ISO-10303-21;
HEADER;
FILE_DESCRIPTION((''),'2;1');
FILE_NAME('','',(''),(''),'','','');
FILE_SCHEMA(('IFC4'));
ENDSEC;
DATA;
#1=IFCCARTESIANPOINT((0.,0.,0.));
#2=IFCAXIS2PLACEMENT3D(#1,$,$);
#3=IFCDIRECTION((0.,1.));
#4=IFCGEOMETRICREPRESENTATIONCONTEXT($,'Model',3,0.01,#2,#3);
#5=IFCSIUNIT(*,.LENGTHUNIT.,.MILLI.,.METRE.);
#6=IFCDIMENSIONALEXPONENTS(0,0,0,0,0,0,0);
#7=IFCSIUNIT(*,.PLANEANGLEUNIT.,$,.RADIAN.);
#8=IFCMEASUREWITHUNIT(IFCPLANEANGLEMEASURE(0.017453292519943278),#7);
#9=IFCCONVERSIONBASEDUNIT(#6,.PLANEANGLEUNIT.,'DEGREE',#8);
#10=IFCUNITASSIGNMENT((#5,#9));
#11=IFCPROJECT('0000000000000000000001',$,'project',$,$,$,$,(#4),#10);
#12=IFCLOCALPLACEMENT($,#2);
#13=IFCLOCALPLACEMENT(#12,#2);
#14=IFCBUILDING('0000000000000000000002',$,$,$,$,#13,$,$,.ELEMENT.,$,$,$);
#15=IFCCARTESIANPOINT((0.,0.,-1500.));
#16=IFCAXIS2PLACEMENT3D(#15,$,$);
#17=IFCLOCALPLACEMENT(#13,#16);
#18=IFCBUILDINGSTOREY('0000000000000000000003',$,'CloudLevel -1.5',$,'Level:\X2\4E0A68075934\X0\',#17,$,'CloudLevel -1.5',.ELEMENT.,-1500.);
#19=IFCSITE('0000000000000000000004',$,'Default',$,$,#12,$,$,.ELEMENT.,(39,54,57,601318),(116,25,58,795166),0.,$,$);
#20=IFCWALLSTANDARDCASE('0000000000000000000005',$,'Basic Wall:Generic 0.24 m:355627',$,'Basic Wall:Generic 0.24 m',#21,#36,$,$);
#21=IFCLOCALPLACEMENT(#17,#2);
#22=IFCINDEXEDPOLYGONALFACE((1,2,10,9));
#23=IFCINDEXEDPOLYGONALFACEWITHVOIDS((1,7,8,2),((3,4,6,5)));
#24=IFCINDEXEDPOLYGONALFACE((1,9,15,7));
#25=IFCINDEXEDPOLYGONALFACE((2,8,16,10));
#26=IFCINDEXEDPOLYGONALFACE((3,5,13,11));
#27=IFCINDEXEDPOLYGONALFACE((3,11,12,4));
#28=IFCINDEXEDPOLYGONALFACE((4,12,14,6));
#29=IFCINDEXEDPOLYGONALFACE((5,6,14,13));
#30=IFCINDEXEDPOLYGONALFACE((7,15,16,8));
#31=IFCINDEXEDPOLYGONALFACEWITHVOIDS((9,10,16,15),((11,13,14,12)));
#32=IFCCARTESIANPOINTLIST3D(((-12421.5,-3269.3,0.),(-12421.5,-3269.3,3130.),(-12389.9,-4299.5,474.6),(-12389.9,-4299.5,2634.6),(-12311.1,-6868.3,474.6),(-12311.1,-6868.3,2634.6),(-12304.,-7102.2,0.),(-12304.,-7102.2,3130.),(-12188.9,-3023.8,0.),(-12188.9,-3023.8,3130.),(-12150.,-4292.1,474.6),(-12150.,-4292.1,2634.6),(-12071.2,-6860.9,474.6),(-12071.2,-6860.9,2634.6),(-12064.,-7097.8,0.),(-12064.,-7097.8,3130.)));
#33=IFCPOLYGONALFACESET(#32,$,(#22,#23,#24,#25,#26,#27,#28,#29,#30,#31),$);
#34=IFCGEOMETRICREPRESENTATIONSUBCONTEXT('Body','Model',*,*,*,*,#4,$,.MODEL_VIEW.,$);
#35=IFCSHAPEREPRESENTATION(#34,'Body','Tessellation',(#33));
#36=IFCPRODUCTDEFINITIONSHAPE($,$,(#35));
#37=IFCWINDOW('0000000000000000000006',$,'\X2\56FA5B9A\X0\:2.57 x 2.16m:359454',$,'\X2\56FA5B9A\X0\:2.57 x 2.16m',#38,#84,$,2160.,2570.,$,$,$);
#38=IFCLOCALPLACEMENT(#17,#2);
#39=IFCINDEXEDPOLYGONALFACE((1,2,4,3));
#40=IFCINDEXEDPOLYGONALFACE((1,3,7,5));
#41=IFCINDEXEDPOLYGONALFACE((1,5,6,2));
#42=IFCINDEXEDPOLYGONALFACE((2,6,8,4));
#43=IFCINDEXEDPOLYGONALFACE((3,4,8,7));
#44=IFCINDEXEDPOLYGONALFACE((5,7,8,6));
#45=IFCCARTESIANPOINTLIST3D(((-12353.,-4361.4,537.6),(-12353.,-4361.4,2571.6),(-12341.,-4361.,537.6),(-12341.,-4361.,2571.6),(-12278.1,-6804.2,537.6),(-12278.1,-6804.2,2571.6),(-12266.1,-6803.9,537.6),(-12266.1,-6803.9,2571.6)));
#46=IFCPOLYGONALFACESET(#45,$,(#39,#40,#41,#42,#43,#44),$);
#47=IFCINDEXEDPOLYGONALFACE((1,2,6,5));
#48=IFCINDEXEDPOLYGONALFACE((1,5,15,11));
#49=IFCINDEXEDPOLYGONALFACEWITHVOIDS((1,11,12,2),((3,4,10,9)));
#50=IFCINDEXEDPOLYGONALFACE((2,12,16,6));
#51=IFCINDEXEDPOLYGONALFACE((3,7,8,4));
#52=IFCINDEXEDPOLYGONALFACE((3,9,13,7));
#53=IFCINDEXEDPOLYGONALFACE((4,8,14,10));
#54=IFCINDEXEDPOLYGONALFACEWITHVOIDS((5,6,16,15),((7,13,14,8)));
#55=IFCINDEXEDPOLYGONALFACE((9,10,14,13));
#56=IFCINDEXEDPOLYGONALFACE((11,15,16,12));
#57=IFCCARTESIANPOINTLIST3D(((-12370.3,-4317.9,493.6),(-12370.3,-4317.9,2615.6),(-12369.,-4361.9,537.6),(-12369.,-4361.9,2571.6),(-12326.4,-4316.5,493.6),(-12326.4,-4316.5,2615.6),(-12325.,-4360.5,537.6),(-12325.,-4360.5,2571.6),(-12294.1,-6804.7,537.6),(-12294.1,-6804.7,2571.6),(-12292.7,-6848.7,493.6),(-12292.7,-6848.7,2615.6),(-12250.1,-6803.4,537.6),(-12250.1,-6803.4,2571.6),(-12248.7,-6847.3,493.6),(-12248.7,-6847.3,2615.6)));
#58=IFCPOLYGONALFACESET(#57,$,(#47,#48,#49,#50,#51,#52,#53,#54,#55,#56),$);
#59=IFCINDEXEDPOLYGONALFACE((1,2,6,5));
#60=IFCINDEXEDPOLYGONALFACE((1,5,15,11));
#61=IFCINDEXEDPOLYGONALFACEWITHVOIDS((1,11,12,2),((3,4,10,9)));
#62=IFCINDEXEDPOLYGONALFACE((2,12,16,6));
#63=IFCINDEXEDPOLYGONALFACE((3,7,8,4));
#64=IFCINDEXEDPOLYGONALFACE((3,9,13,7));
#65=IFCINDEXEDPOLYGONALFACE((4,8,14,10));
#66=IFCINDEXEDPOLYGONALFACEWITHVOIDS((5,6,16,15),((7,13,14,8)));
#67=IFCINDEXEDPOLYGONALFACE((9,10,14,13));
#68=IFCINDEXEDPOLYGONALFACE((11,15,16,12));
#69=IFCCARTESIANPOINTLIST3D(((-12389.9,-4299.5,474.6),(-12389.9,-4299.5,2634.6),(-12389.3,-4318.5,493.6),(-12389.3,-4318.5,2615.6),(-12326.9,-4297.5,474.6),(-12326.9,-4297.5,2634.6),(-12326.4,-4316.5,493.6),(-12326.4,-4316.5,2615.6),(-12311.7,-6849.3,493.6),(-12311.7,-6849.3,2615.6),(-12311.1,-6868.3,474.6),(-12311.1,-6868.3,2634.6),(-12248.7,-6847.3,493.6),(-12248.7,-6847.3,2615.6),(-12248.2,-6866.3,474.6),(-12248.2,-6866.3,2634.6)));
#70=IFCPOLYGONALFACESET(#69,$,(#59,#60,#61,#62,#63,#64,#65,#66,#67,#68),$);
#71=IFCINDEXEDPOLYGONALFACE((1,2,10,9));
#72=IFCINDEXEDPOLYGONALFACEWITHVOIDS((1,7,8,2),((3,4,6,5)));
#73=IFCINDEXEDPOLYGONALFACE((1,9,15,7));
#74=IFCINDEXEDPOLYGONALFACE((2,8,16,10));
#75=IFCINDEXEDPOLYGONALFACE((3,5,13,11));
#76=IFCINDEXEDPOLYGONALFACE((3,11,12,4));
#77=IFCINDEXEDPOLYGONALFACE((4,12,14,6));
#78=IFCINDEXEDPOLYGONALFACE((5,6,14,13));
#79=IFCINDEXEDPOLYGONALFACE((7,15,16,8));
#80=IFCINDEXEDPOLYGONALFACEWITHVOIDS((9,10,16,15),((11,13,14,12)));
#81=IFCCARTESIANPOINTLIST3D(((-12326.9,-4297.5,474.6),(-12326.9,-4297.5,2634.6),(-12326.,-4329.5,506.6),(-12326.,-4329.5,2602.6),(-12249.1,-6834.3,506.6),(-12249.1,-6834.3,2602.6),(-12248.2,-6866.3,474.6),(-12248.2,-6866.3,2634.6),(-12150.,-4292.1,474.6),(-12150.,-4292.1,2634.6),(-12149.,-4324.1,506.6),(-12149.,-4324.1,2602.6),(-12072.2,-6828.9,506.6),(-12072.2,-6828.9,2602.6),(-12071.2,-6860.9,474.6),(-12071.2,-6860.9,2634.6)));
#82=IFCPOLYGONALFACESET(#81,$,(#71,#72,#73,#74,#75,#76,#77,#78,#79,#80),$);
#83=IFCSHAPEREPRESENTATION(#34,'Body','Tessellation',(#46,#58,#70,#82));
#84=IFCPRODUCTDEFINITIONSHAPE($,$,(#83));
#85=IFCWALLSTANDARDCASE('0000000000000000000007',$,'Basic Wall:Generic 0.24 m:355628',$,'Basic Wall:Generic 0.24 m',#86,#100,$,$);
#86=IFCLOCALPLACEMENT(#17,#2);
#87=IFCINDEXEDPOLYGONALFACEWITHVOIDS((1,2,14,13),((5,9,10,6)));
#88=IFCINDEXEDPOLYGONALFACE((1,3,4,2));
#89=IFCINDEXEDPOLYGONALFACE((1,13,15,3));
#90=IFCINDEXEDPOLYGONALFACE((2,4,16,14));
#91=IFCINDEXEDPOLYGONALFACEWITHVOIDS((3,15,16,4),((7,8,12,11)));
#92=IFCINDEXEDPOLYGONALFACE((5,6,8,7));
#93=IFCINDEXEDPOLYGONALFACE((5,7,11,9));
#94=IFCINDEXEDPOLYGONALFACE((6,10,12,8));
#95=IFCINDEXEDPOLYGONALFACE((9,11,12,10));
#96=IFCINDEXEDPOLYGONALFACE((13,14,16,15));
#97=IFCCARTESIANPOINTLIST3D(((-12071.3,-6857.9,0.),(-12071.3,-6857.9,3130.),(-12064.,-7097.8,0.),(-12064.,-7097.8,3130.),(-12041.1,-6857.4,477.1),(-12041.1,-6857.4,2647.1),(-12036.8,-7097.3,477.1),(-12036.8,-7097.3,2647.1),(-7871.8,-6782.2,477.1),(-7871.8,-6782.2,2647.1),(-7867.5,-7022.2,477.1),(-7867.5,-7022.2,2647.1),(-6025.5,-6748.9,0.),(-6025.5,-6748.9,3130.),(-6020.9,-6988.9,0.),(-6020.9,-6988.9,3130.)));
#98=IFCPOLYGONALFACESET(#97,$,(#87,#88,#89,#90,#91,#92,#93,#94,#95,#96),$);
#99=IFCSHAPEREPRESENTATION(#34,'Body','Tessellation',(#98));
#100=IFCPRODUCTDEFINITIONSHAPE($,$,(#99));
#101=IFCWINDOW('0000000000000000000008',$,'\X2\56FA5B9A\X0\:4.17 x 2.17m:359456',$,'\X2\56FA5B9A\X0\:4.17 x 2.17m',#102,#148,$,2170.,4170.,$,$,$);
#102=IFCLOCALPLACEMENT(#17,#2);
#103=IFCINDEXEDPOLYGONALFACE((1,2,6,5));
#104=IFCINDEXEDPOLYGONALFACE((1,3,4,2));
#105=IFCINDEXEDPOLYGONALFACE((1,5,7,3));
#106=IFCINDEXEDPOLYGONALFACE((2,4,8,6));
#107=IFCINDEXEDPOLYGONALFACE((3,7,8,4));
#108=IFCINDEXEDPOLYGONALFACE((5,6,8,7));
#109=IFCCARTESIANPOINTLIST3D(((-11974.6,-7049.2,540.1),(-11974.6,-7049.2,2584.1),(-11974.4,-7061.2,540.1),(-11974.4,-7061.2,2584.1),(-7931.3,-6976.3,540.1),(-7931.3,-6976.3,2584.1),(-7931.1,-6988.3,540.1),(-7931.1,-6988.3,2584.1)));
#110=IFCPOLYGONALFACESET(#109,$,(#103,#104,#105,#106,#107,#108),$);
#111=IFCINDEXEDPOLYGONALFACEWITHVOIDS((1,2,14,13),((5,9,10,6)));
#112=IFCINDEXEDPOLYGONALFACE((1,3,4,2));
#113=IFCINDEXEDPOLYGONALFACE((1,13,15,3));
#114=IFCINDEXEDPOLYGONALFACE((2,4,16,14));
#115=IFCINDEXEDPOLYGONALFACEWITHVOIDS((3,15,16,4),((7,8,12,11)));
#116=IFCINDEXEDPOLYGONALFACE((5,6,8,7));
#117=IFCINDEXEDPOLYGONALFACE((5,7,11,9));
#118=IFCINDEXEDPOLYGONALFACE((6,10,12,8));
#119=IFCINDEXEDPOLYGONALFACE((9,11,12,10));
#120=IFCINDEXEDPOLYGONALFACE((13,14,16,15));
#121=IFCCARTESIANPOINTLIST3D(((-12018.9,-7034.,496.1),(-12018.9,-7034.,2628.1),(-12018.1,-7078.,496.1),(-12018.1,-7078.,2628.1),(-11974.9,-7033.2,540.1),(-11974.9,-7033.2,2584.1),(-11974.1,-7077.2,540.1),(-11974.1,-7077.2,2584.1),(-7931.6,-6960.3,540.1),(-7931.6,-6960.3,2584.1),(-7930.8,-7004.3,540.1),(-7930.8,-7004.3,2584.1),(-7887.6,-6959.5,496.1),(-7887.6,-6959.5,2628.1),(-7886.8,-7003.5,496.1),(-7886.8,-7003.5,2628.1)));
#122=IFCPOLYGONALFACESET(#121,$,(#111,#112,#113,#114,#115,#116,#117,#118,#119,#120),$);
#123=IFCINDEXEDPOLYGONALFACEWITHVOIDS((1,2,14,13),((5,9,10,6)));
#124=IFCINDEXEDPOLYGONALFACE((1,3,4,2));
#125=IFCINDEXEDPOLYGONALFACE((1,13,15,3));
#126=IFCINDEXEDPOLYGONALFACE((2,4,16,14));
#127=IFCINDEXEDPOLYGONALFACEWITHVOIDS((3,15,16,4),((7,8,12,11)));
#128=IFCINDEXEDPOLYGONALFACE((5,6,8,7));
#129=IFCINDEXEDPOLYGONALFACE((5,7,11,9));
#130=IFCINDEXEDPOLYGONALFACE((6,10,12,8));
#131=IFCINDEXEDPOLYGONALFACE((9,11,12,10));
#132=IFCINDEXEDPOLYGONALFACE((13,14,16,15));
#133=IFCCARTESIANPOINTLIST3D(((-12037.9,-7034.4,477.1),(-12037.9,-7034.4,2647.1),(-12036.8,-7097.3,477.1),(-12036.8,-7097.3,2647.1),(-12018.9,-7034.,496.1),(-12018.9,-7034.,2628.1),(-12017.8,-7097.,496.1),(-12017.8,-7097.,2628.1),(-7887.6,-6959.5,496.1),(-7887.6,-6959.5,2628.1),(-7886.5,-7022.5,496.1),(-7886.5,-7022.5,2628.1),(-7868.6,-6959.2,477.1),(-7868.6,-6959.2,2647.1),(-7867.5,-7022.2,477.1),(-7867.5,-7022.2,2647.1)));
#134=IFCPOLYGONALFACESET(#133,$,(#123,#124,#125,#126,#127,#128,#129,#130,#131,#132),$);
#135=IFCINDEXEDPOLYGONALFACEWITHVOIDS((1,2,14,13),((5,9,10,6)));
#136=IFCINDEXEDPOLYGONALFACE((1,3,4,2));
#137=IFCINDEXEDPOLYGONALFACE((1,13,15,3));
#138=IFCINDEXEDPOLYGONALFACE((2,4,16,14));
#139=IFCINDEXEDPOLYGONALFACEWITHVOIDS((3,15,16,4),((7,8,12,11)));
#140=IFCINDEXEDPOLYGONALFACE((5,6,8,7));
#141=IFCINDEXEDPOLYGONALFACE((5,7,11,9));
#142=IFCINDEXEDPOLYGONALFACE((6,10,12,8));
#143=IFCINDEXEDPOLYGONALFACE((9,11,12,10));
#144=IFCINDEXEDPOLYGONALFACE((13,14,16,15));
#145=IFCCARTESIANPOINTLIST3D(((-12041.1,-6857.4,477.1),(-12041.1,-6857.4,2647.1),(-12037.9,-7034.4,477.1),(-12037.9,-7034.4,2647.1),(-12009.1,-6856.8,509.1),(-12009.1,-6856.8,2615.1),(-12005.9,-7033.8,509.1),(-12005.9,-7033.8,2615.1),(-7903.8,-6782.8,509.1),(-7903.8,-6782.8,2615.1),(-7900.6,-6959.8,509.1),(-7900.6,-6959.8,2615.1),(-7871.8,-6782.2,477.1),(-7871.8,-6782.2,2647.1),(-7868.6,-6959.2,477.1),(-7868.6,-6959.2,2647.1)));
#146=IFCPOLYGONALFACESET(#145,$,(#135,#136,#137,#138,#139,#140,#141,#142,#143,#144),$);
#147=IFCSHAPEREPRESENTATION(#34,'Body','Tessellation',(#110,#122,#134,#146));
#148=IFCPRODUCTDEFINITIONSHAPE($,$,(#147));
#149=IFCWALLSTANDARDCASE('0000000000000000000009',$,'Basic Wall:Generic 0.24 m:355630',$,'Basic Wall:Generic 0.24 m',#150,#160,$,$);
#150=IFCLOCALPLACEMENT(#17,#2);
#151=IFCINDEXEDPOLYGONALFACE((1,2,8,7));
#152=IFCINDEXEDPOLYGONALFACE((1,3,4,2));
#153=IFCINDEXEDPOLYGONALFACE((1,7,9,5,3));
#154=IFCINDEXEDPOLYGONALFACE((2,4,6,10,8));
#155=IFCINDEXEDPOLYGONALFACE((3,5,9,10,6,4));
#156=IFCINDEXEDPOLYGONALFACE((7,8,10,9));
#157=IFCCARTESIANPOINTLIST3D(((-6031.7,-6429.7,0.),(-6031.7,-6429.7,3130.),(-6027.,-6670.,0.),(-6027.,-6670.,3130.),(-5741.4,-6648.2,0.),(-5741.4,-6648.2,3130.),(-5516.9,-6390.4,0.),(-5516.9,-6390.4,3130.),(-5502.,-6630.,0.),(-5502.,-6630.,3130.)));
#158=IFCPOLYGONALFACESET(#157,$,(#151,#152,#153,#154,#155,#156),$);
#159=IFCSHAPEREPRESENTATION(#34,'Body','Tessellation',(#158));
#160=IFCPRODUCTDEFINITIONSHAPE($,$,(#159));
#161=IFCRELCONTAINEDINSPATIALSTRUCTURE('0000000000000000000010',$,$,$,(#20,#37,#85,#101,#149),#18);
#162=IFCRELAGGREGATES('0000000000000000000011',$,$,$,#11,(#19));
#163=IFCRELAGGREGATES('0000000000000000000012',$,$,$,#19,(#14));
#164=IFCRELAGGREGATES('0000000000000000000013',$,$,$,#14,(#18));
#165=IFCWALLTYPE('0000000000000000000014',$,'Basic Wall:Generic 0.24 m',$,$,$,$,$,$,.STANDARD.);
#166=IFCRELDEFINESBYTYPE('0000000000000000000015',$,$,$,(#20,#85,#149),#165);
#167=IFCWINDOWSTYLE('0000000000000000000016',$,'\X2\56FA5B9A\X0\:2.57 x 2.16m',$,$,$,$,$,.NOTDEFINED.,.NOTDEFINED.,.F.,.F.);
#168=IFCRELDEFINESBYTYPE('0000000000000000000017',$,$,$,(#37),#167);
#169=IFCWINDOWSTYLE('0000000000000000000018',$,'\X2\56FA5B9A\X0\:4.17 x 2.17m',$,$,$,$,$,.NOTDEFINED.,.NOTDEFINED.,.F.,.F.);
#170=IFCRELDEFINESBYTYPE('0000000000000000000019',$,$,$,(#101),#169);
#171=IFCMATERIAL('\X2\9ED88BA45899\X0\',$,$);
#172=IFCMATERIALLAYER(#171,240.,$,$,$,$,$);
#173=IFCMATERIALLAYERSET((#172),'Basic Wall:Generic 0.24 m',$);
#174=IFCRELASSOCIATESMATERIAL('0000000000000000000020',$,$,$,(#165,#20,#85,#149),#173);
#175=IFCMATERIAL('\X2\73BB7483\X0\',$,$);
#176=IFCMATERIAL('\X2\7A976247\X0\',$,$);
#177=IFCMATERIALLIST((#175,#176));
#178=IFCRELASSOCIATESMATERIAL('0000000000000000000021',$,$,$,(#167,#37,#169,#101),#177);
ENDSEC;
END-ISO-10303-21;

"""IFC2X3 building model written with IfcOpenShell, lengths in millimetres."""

from ifc_helpers import new_model, entity, si_unit, converted_unit, direction, frame, frame_2d, origin, place, context, subcontext, project, spatial, polyline, rectangle, outline, extrude, source, transform, mapped, material, material_list, layer, layer_set, layer_usage, type_object, type_shapes, element, fill, save


model = new_model("IFC2X3")

# Units and contexts
model_context = context("Model", 3, precision=0.01, world=origin(), true_north=direction((0.0, 1.0)))
body_context = subcontext(model_context, "Body", "Model", "MODEL_VIEW")
ifc_project = project(units=[si_unit("LENGTHUNIT", "METRE", prefix="MILLI"), converted_unit("PLANEANGLEUNIT", "DEGREE", entity("IfcPlaneAngleMeasure", 0.017453292519943278), si_unit("PLANEANGLEUNIT", "RADIAN"), dimensions=[0, 0, 0, 0, 0, 0, 0])], contexts=[model_context])

# Site, building, storey
site_placement = place(None, origin())
site = spatial("IfcSite", under=ifc_project, at=site_placement, Name="Default", CompositionType="ELEMENT", RefLatitude=(39, 54, 57, 601318), RefLongitude=(116, 25, 58, 795166), RefElevation=0.0)
building_placement = place(site_placement, origin())
building = spatial("IfcBuilding", under=site, at=building_placement, CompositionType="ELEMENT")
storey_placement = place(building_placement, frame((0.0, 0.0, -1500.0)))
storey = spatial("IfcBuildingStorey", under=building, at=storey_placement, Name="CloudLevel -1.5", ObjectType="Level:上标头", LongName="CloudLevel -1.5", CompositionType="ELEMENT", Elevation=-1500.0)

# Shared definitions
ifc_material_1 = material(Name="默认墙")
ifc_layer_1 = layer(ifc_material_1, 240.0)
ifc_layer_set_1 = layer_set([ifc_layer_1], Name="Basic Wall:Generic 0.24 m")
ifc_layer_usage_1 = layer_usage(ifc_layer_set_1, "AXIS2", "NEGATIVE", 120.0)
wall_type_1 = type_object("IfcWallType", Name="Basic Wall:Generic 0.24 m", PredefinedType="STANDARD", material=ifc_layer_set_1)

# Wall, opening, window
wall_1_placement = place(storey_placement, frame((-12308.9, -3027.5, 0.0), z_axis=(0.0, 0.0, 1.0), x_axis=(0.030657, -0.99953, 0.0)))
wall_1 = element("IfcWallStandardCase", 1, at=wall_1_placement, inside=storey, type_object=wall_type_1, material=ifc_layer_usage_1, Name="Basic Wall:Generic 0.24 m:355627", ObjectType="Basic Wall:Generic 0.24 m", context=body_context, shape_type="SweptSolid", body=[
    extrude(outline(polyline([(4072.9, -120.0), (4075.9, 120.0), (3835.9, 120.0), (0.0, 120.0), (238.3, -120.0), (348.5, -120.0), (4072.9, -120.0)])), origin(), (0.0, 0.0, 1.0), 3130.0),
])
opening_1_placement = place(wall_1_placement, frame((3838.9, 120.0, 474.6)))
opening_1 = element("IfcOpeningElement", 2, at=opening_1_placement, cuts=wall_1, ObjectType="Opening", context=body_context, shape_type="SweptSolid", body=[
    extrude(rectangle(XDim=2160.0, YDim=2570.0, at=frame_2d((1080.0, 1285.0), x_axis=(1.0, 0.0))), frame((0.0, 0.0, 0.0), z_axis=(0.0, -1.0, 0.0), x_axis=(0.0, 0.0, 1.0)), (0.0, 0.0, 1.0), 240.0),
])
ifc_material_2 = material(Name="玻璃")
ifc_material_3 = material(Name="窗扇")
ifc_material_list_1 = material_list([ifc_material_2, ifc_material_3])
window_style_1 = type_object("IfcWindowStyle", Name="固定:2.57 x 2.16m", ConstructionType="NOTDEFINED", OperationType="NOTDEFINED", ParameterTakesPrecedence=False, Sizeable=False, material=ifc_material_list_1)
shared_shape_1 = source(origin(), body_context, "Body", "SweptSolid", [
    extrude(rectangle(XDim=2444.0, YDim=12.0, at=frame_2d((0.0, 0.0), x_axis=(1.0, 0.0))), frame((1285.0, 225.0, 63.0), z_axis=(0.0, 0.0, 1.0), x_axis=(-1.0, 0.0, 0.0)), (0.0, 0.0, 1.0), 2034.0),
    extrude(outline(polyline([(-1266.0, -1061.0), (1266.0, -1061.0), (1266.0, 1061.0), (-1266.0, 1061.0), (-1266.0, -1061.0)]), holes=[polyline([(-1222.0, -1017.0), (-1222.0, 1017.0), (1222.0, 1017.0), (1222.0, -1017.0), (-1222.0, -1017.0)])]), frame((1285.0, 247.0, 1080.0), z_axis=(0.0, -1.0, 0.0), x_axis=(-1.0, 0.0, 0.0)), (0.0, 0.0, 1.0), 44.0),
    extrude(outline(polyline([(-1285.0, -1080.0), (1285.0, -1080.0), (1285.0, 1080.0), (-1285.0, 1080.0), (-1285.0, -1080.0)]), holes=[polyline([(-1266.0, -1061.0), (-1266.0, 1061.0), (1266.0, 1061.0), (1266.0, -1061.0), (-1266.0, -1061.0)])]), frame((1285.0, 266.0, 1080.0), z_axis=(0.0, -1.0, 0.0), x_axis=(-1.0, 0.0, 0.0)), (0.0, 0.0, 1.0), 63.0),
    extrude(outline(polyline([(-1285.0, -1080.0), (1285.0, -1080.0), (1285.0, 1080.0), (-1285.0, 1080.0), (-1285.0, -1080.0)]), holes=[polyline([(-1253.0, -1048.0), (-1253.0, 1048.0), (1253.0, 1048.0), (1253.0, -1048.0), (-1253.0, -1048.0)])]), frame((1285.0, 203.0, 1080.0), z_axis=(0.0, -1.0, 0.0), x_axis=(-1.0, 0.0, 0.0)), (0.0, 0.0, 1.0), 177.0),
])
type_shapes(window_style_1, [shared_shape_1])
window_1_placement = place(opening_1_placement, frame((0.0, 26.0, 0.0), z_axis=(0.0, 0.0, 1.0), x_axis=(-1.0, 0.0, 0.0)))
window_1 = element("IfcWindow", 3, at=window_1_placement, inside=storey, type_object=window_style_1, material=ifc_material_list_1, Name="固定:2.57 x 2.16m:359454", ObjectType="固定:2.57 x 2.16m", OverallHeight=2160.0, OverallWidth=2570.0, context=body_context, shape_type="MappedRepresentation", body=[
    mapped(shared_shape_1, transform((0.0, 0.0, 0.0), scale=1.0)),
])
fill(opening_1, window_1)

# Wall, openings, window
wall_2_placement = place(storey_placement, frame((-12069.2, -6977.9, 0.0), z_axis=(0.0, 0.0, 1.0), x_axis=(0.999838, 0.018026, 0.0)))
wall_2 = element("IfcWallStandardCase", 4, at=wall_2_placement, inside=storey, type_object=wall_type_1, material=ifc_layer_usage_1, Name="Basic Wall:Generic 0.24 m:355628", ObjectType="Basic Wall:Generic 0.24 m", context=body_context, shape_type="SweptSolid", body=[
    extrude(outline(polyline([(6047.1, -120.0), (6046.8, 120.0), (5716.8, 120.0), (0.0, 120.0), (3.0, -120.0), (6047.1, -120.0)])), origin(), (0.0, 0.0, 1.0), 3130.0),
])
opening_2_placement = place(wall_2_placement, origin())
element("IfcOpeningElement", 5, at=opening_2_placement, cuts=wall_2, ObjectType="Opening", context=body_context, shape_type="SweptSolid", body=[
    extrude(rectangle(XDim=2160.0, YDim=240.0, at=frame_2d((0.0, 0.0), x_axis=(0.0, 1.0))), frame((-120.0, 115.5, 1554.6), z_axis=(-0.012634, 0.99992, 0.0), x_axis=(-0.99992, -0.012634, 0.0)), (0.0, 0.0, 1.0), 2570.0),
])
opening_3_placement = place(wall_2_placement, frame((4200.2, 120.0, 477.1)))
opening_3 = element("IfcOpeningElement", 6, at=opening_3_placement, cuts=wall_2, ObjectType="Opening", context=body_context, shape_type="SweptSolid", body=[
    extrude(rectangle(XDim=2170.0, YDim=4170.0, at=frame_2d((1085.0, 2085.0), x_axis=(1.0, 0.0))), frame((0.0, 0.0, 0.0), z_axis=(0.0, -1.0, 0.0), x_axis=(0.0, 0.0, 1.0)), (0.0, 0.0, 1.0), 240.0),
])
window_style_2 = type_object("IfcWindowStyle", Name="固定:4.17 x 2.17m", ConstructionType="NOTDEFINED", OperationType="NOTDEFINED", ParameterTakesPrecedence=False, Sizeable=False, material=ifc_material_list_1)
shared_shape_2 = source(origin(), body_context, "Body", "SweptSolid", [
    extrude(rectangle(XDim=4044.0, YDim=12.0, at=frame_2d((0.0, 0.0), x_axis=(1.0, 0.0))), frame((2085.0, 225.0, 63.0), z_axis=(0.0, 0.0, 1.0), x_axis=(-1.0, 0.0, 0.0)), (0.0, 0.0, 1.0), 2044.0),
    extrude(outline(polyline([(-2066.0, -1066.0), (2066.0, -1066.0), (2066.0, 1066.0), (-2066.0, 1066.0), (-2066.0, -1066.0)]), holes=[polyline([(-2022.0, -1022.0), (-2022.0, 1022.0), (2022.0, 1022.0), (2022.0, -1022.0), (-2022.0, -1022.0)])]), frame((2085.0, 247.0, 1085.0), z_axis=(0.0, -1.0, 0.0), x_axis=(-1.0, 0.0, 0.0)), (0.0, 0.0, 1.0), 44.0),
    extrude(outline(polyline([(-2085.0, -1085.0), (2085.0, -1085.0), (2085.0, 1085.0), (-2085.0, 1085.0), (-2085.0, -1085.0)]), holes=[polyline([(-2066.0, -1066.0), (-2066.0, 1066.0), (2066.0, 1066.0), (2066.0, -1066.0), (-2066.0, -1066.0)])]), frame((2085.0, 266.0, 1085.0), z_axis=(0.0, -1.0, 0.0), x_axis=(-1.0, 0.0, 0.0)), (0.0, 0.0, 1.0), 63.0),
    extrude(outline(polyline([(-2085.0, -1085.0), (2085.0, -1085.0), (2085.0, 1085.0), (-2085.0, 1085.0), (-2085.0, -1085.0)]), holes=[polyline([(-2053.0, -1053.0), (-2053.0, 1053.0), (2053.0, 1053.0), (2053.0, -1053.0), (-2053.0, -1053.0)])]), frame((2085.0, 203.0, 1085.0), z_axis=(0.0, -1.0, 0.0), x_axis=(-1.0, 0.0, 0.0)), (0.0, 0.0, 1.0), 177.0),
])
type_shapes(window_style_2, [shared_shape_2])
window_2_placement = place(opening_3_placement, frame((0.0, 26.0, 0.0), z_axis=(0.0, 0.0, 1.0), x_axis=(-1.0, 0.0, 0.0)))
window_2 = element("IfcWindow", 7, at=window_2_placement, inside=storey, type_object=window_style_2, material=ifc_material_list_1, Name="固定:4.17 x 2.17m:359456", ObjectType="固定:4.17 x 2.17m", OverallHeight=2170.0, OverallWidth=4170.0, context=body_context, shape_type="MappedRepresentation", body=[
    mapped(shared_shape_2, transform((0.0, 0.0, 0.0), scale=1.0)),
])
fill(opening_3, window_2)

# Wall
wall_3_placement = place(storey_placement, frame((-6036.2, -6550.4, 0.0), z_axis=(0.0, 0.0, 1.0), x_axis=(0.997101, 0.076089, 0.0)))
element("IfcWallStandardCase", 8, at=wall_3_placement, inside=storey, type_object=wall_type_1, material=ifc_layer_usage_1, Name="Basic Wall:Generic 0.24 m:355630", ObjectType="Basic Wall:Generic 0.24 m", context=body_context, shape_type="SweptSolid", body=[
    extrude(outline(polyline([(526.5, -120.0), (529.9, 120.0), (13.6, 120.0), (0.0, -120.0), (286.5, -120.0), (526.5, -120.0)])), origin(), (0.0, 0.0, 1.0), 3130.0),
])

save(model, "model.ifc")
